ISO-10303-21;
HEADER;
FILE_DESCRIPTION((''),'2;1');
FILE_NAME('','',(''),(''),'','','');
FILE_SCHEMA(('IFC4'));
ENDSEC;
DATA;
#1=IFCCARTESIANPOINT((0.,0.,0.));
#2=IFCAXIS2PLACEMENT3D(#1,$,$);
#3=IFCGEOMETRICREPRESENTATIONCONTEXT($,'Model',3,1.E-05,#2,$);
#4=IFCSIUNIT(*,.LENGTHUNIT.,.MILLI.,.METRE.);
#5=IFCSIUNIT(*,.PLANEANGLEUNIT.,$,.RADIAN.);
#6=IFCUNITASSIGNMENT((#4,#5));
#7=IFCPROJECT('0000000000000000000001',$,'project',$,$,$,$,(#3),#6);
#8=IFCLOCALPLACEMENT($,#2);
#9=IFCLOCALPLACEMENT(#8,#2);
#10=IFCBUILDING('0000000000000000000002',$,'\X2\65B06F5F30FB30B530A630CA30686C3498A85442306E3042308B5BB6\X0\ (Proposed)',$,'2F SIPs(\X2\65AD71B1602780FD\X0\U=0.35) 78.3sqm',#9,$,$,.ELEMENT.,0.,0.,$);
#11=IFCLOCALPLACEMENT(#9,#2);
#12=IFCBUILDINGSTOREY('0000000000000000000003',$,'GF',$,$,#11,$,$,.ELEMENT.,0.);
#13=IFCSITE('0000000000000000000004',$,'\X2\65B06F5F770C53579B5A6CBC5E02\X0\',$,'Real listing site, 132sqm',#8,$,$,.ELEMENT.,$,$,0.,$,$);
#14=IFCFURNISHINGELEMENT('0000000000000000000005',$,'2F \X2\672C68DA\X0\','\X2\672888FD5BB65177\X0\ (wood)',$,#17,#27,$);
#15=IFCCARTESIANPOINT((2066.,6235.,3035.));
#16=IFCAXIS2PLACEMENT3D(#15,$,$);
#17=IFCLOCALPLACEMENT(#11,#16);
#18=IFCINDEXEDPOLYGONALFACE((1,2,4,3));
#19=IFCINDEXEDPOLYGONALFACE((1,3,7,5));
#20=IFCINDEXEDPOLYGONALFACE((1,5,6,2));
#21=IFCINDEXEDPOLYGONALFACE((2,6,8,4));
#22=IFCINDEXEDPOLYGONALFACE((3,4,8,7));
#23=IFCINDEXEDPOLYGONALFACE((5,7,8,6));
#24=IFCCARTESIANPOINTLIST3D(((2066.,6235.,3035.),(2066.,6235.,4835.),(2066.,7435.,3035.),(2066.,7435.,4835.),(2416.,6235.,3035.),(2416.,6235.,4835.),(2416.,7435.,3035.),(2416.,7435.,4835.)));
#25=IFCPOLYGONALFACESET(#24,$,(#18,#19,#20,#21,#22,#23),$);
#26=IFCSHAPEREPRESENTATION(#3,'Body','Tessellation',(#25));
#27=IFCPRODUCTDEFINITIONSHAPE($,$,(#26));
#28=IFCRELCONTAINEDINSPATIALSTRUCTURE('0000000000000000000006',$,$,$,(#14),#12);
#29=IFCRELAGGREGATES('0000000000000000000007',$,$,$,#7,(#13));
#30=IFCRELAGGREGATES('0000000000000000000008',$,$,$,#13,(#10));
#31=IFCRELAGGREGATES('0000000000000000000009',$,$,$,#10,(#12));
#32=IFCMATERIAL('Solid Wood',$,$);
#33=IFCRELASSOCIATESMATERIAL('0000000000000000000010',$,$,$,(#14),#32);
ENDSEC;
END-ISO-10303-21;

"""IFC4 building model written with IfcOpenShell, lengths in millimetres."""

from ifc_helpers import new_model, si_unit, frame, frame_2d, origin, place, context, project, spatial, rectangle, extrude, material, element, save


model = new_model("IFC4")

# Units and contexts
model_context = context("Model", 3, precision=1e-05, world=origin())
ifc_project = project(units=[si_unit("LENGTHUNIT", "METRE", prefix="MILLI"), si_unit("PLANEANGLEUNIT", "RADIAN")], contexts=[model_context])

# Site, building, storey
site_placement = place(None, origin())
site = spatial("IfcSite", under=ifc_project, at=site_placement, Name="新潟県南魚沼市", ObjectType="Real listing site, 132sqm", CompositionType="ELEMENT", RefElevation=0.0)
building_placement = place(site_placement, origin())
building = spatial("IfcBuilding", under=site, at=building_placement, Name="新潟・サウナと水風呂のある家 (Proposed)", ObjectType="2F SIPs(断熱性能U=0.35) 78.3sqm", CompositionType="ELEMENT", ElevationOfRefHeight=0.0, ElevationOfTerrain=0.0)
storey_placement = place(building_placement, origin())
storey = spatial("IfcBuildingStorey", under=building, at=storey_placement, Name="GF", CompositionType="ELEMENT", Elevation=0.0)

# Shared definitions
ifc_material_1 = material(Name="Solid Wood")

# Furnishing element
furnishing_placement = place(storey_placement, frame((2066.0, 6235.0, 3035.0)))
element("IfcFurnishingElement", 1, at=furnishing_placement, inside=storey, material=ifc_material_1, Name="2F 本棚", Description="木製家具 (wood)", context=model_context, shape_type="SweptSolid", body=[
    extrude(rectangle(XDim=350.0, YDim=1200.0, at=frame_2d((175.0, 600.0))), frame((2066.0, 6235.0, 3035.0)), (0.0, 0.0, 1.0), 1800.0),
])

save(model, "model.ifc")
